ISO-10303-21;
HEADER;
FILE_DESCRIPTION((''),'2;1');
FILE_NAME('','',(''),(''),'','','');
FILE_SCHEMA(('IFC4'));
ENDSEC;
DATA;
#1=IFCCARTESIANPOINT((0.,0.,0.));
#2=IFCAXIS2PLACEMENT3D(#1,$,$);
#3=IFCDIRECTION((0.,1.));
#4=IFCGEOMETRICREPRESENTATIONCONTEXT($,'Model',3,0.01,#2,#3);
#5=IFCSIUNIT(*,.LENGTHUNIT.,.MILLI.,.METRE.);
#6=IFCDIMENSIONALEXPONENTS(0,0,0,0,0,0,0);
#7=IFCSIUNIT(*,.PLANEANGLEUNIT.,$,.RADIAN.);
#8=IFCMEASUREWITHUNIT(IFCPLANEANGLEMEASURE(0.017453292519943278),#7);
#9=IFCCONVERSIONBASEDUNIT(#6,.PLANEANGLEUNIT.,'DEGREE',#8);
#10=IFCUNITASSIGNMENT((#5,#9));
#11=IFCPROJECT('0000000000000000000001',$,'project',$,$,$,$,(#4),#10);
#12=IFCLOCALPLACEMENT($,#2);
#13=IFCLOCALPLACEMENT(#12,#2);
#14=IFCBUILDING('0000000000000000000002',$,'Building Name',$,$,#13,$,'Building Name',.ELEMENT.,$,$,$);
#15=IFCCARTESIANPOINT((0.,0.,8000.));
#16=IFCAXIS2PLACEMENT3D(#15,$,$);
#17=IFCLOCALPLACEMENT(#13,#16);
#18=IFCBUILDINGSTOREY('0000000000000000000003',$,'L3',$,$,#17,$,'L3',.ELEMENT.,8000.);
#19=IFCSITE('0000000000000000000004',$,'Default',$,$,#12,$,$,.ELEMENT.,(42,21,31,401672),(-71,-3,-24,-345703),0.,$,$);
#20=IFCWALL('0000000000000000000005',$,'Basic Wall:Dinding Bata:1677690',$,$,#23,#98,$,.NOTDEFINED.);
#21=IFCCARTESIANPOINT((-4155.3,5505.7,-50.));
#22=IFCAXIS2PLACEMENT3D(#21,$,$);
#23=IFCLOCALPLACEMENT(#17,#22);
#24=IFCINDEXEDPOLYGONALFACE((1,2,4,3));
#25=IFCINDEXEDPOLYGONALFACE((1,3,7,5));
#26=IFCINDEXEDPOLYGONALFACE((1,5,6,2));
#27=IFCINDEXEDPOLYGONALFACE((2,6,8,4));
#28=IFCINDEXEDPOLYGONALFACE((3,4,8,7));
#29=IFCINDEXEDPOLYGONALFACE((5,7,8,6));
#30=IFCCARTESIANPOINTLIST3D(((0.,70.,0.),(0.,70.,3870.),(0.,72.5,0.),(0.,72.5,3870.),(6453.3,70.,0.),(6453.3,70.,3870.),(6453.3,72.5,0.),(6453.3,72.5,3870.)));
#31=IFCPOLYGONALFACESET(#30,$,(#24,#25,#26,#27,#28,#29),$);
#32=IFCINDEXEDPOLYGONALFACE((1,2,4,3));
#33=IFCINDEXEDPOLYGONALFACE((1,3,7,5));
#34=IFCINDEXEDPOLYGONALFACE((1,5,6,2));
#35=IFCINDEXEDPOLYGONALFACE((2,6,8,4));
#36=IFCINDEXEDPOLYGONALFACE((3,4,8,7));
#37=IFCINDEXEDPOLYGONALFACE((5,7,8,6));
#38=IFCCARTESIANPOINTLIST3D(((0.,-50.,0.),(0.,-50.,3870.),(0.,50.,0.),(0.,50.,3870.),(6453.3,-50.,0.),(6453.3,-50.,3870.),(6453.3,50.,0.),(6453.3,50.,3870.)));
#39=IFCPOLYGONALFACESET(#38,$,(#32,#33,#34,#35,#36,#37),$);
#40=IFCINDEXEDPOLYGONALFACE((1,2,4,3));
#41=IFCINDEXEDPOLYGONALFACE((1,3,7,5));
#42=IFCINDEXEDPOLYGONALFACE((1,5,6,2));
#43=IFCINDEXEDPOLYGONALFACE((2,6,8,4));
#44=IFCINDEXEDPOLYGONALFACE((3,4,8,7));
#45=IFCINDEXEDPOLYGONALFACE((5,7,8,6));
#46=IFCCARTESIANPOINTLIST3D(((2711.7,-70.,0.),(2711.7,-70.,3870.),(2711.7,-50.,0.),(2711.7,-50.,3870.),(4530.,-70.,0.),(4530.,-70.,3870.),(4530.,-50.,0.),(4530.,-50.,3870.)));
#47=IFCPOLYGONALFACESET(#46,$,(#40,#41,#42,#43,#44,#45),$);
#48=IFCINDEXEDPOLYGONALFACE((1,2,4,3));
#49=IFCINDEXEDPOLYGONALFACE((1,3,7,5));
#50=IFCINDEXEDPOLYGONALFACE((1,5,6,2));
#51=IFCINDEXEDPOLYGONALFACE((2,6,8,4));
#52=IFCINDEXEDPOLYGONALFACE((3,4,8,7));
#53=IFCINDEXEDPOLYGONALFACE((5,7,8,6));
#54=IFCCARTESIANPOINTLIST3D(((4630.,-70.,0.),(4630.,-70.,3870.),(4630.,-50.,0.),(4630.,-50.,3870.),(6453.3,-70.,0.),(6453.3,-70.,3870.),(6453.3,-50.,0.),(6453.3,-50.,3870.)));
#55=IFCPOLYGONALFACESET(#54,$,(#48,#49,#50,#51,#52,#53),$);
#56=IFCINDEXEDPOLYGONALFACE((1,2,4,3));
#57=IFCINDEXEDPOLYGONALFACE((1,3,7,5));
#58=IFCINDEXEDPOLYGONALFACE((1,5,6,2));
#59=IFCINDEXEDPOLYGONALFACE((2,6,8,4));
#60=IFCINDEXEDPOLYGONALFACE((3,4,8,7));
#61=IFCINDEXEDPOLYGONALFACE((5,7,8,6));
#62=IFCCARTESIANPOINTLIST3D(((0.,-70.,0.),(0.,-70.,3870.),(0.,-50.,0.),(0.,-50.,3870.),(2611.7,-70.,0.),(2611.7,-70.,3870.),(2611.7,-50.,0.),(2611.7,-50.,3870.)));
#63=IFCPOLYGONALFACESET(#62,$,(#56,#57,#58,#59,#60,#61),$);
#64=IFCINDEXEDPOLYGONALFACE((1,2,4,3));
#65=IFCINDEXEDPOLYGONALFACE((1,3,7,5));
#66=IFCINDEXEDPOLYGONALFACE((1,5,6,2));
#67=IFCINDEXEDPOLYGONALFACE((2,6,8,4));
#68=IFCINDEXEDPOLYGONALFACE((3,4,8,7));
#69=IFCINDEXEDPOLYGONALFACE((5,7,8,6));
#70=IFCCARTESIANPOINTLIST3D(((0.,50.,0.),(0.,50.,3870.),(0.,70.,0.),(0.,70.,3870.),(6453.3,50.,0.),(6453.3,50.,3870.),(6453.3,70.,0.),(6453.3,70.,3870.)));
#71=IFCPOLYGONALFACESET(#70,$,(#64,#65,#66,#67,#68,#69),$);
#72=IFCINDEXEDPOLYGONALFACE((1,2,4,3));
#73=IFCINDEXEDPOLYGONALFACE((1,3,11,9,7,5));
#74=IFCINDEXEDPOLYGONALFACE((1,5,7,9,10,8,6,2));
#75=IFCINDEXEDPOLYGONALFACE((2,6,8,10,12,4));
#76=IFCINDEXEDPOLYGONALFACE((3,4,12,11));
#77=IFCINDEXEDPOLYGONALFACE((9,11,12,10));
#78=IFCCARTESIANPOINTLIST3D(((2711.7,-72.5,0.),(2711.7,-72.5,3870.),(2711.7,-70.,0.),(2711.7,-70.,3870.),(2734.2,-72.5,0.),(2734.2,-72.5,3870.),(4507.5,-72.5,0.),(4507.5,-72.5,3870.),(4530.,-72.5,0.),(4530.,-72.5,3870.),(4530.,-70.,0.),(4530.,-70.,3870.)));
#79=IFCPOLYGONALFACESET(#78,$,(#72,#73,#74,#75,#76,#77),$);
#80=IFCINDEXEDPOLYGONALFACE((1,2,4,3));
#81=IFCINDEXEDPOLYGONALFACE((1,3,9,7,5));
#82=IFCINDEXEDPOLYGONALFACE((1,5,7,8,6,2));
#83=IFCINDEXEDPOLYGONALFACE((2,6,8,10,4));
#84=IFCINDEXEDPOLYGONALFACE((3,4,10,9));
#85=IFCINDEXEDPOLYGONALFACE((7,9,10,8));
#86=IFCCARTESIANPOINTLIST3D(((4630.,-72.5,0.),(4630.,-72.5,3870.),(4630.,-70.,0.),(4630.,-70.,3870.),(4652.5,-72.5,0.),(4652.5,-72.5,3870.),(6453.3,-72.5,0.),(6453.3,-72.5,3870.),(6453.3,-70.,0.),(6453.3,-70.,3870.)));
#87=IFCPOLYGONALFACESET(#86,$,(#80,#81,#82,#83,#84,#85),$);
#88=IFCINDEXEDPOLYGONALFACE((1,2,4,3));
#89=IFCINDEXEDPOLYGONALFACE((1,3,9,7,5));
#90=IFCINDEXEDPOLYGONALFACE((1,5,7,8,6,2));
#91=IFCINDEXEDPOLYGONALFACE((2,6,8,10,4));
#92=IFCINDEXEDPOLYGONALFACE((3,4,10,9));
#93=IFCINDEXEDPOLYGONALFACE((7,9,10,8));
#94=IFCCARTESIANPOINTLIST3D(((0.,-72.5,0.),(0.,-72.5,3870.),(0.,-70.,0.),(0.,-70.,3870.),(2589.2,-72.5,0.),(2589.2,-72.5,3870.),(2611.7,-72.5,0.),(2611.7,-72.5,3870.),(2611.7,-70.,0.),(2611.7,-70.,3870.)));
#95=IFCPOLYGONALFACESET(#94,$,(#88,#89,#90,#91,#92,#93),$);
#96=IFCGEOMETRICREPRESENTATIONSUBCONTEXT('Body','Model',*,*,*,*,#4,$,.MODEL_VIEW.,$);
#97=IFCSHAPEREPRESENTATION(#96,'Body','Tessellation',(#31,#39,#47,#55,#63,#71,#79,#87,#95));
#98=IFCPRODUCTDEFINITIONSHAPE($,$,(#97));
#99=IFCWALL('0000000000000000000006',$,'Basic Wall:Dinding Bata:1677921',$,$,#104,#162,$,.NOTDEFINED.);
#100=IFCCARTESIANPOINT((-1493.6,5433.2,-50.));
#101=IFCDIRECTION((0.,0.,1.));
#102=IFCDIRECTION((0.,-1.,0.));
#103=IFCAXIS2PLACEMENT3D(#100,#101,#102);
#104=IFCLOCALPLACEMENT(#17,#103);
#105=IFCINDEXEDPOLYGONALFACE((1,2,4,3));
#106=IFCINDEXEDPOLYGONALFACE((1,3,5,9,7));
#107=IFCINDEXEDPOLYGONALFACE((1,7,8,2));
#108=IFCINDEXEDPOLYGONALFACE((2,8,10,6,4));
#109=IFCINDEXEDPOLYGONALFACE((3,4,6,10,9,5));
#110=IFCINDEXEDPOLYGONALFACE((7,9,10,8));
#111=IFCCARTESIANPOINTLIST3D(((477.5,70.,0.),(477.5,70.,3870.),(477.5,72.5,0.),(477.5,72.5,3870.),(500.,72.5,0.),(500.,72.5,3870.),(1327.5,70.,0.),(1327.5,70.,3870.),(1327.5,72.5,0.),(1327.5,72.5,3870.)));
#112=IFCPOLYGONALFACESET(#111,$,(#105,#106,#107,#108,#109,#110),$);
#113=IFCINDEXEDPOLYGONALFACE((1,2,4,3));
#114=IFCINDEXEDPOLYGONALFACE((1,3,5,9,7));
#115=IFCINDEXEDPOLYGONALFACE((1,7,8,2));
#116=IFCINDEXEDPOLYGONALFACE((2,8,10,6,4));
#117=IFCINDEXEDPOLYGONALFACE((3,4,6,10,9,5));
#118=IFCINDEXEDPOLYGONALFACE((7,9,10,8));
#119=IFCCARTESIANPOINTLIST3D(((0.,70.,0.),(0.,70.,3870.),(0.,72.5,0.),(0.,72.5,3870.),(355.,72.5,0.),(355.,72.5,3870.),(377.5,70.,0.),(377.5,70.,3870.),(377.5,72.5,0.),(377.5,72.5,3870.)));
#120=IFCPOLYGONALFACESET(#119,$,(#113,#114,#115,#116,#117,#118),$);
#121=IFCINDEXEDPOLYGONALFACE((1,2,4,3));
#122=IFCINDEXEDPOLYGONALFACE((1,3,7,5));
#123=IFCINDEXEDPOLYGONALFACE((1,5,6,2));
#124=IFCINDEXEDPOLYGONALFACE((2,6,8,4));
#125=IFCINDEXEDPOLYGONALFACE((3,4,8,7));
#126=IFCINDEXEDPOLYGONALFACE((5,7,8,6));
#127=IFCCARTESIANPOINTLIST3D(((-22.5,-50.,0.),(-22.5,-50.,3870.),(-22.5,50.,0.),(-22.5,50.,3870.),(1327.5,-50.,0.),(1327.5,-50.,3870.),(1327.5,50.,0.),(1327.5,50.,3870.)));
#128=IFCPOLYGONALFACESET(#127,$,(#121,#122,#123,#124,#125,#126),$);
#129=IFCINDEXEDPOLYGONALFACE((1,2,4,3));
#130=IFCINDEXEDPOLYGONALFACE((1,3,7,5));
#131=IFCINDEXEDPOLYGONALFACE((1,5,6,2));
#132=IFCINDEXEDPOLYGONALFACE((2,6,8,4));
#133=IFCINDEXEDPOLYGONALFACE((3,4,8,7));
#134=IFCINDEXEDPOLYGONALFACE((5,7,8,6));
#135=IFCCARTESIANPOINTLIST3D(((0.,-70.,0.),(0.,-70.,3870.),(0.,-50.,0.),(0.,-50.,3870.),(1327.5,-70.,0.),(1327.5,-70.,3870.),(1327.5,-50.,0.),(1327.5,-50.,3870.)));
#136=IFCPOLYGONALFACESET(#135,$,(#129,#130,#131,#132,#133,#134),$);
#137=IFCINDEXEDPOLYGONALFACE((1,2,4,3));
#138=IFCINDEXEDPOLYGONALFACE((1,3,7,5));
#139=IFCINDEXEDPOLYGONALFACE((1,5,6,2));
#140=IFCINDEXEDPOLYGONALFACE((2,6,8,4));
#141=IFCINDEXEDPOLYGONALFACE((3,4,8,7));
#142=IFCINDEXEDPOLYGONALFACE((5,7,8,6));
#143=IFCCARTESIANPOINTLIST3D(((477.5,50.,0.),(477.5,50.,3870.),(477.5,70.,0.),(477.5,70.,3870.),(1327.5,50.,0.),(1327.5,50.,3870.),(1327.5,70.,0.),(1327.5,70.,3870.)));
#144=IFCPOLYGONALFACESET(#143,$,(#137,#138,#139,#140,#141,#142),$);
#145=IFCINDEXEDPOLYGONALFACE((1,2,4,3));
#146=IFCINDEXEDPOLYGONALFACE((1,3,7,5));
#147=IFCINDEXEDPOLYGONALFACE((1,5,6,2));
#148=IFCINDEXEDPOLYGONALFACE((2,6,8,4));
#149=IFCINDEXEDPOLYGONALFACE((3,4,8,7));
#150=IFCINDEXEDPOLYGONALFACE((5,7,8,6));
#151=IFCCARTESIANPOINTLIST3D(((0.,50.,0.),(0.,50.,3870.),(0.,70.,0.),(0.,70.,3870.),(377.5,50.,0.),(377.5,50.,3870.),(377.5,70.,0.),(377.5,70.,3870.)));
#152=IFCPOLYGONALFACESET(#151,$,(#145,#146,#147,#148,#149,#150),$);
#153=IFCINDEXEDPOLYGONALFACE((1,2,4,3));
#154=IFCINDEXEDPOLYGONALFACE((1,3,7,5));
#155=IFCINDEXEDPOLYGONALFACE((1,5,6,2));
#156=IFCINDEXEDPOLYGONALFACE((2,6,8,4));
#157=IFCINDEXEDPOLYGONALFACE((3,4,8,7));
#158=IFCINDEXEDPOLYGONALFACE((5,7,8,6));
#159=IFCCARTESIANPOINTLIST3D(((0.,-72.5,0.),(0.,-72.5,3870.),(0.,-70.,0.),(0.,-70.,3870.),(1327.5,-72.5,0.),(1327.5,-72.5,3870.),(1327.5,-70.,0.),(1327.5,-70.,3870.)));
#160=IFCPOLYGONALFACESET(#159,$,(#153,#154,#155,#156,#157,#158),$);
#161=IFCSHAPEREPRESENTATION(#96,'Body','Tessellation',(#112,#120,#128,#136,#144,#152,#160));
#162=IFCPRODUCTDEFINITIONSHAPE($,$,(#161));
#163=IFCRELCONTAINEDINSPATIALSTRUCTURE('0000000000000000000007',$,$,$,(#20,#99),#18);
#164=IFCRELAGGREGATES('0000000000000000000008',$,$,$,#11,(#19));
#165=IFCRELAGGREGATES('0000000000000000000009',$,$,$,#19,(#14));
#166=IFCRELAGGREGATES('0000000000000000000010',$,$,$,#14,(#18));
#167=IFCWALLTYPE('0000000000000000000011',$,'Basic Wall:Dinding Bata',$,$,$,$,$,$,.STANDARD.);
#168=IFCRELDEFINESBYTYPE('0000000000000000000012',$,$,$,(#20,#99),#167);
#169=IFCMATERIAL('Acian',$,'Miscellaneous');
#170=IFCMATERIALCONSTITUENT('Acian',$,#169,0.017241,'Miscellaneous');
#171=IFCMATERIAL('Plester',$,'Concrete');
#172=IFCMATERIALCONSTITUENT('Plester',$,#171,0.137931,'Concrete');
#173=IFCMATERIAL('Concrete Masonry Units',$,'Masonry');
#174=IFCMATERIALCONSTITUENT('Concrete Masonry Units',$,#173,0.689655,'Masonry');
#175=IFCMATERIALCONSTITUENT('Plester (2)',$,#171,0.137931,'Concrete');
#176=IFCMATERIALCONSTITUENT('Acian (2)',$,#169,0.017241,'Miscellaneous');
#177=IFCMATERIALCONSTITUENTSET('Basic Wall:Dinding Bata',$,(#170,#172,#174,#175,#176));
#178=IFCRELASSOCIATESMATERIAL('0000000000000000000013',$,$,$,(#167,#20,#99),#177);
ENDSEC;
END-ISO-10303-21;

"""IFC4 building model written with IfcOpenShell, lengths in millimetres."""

from ifc_helpers import new_model, entity, si_unit, converted_unit, direction, frame, origin, place, context, subcontext, project, spatial, indexed_curve, outline, extrude, material, constituent, constituent_set, type_object, element, save


model = new_model("IFC4")

# Units and contexts
model_context = context("Model", 3, precision=0.01, world=origin(), true_north=direction((0.0, 1.0)))
body_context = subcontext(model_context, "Body", "Model", "MODEL_VIEW")
ifc_project = project(units=[si_unit("LENGTHUNIT", "METRE", prefix="MILLI"), converted_unit("PLANEANGLEUNIT", "DEGREE", entity("IfcPlaneAngleMeasure", 0.017453292519943278), si_unit("PLANEANGLEUNIT", "RADIAN"), dimensions=[0, 0, 0, 0, 0, 0, 0])], contexts=[model_context])

# Site, building, storey
site_placement = place(None, origin())
site = spatial("IfcSite", under=ifc_project, at=site_placement, Name="Default", CompositionType="ELEMENT", RefLatitude=(42, 21, 31, 401672), RefLongitude=(-71, -3, -24, -345703), RefElevation=0.0)
building_placement = place(site_placement, origin())
building = spatial("IfcBuilding", under=site, at=building_placement, Name="Building Name", LongName="Building Name", CompositionType="ELEMENT")
storey_placement = place(building_placement, frame((0.0, 0.0, 8000.0)))
storey = spatial("IfcBuildingStorey", under=building, at=storey_placement, Name="L3", LongName="L3", CompositionType="ELEMENT", Elevation=8000.0)

# Walls
ifc_material_1 = material(Name="Acian", Category="Miscellaneous")
ifc_constituent_1 = constituent(ifc_material_1, Name="Acian", Category="Miscellaneous", fraction=0.017241)
ifc_material_2 = material(Name="Plester", Category="Concrete")
ifc_constituent_2 = constituent(ifc_material_2, Name="Plester", Category="Concrete", fraction=0.137931)
ifc_material_3 = material(Name="Concrete Masonry Units", Category="Masonry")
ifc_constituent_3 = constituent(ifc_material_3, Name="Concrete Masonry Units", Category="Masonry", fraction=0.689655)
ifc_constituent_4 = constituent(ifc_material_2, Name="Plester (2)", Category="Concrete", fraction=0.137931)
ifc_constituent_5 = constituent(ifc_material_1, Name="Acian (2)", Category="Miscellaneous", fraction=0.017241)
ifc_constituent_set = constituent_set(constituents=[ifc_constituent_1, ifc_constituent_2, ifc_constituent_3, ifc_constituent_4, ifc_constituent_5], Name="Basic Wall:Dinding Bata")
wall_type = type_object("IfcWallType", Name="Basic Wall:Dinding Bata", PredefinedType="STANDARD", material=ifc_constituent_set)
wall_1_placement = place(storey_placement, frame((-4155.3, 5505.7, -50.0)))
element("IfcWall", 1, at=wall_1_placement, inside=storey, type_object=wall_type, material=ifc_constituent_set, Name="Basic Wall:Dinding Bata:1677690", PredefinedType="NOTDEFINED", context=body_context, shape_type="SweptSolid", body=[
    extrude(outline(indexed_curve([(-1.3, -3226.7), (1.2, -3226.7), (1.3, 3226.7), (-1.2, 3226.7), (-1.3, -3226.7)], self_intersect=False)), frame((3226.7, 71.3, 0.0), z_axis=(0.0, 0.0, 1.0), x_axis=(0.0, -1.0, 0.0)), (0.0, 0.0, 1.0), 3870.0),
    extrude(outline(indexed_curve([(-3226.7, -50.0), (3226.7, -50.0), (3226.7, 50.0), (-3226.7, 50.0), (-3226.7, -50.0)], self_intersect=False)), frame((3226.7, 0.0, 0.0)), (0.0, 0.0, 1.0), 3870.0),
    extrude(outline(indexed_curve([(-909.1, -10.0), (909.1, -10.0), (909.1, 10.0), (-909.1, 10.0), (-909.1, -10.0)], self_intersect=False)), frame((3620.9, -60.0, 0.0), z_axis=(0.0, 0.0, 1.0), x_axis=(-1.0, 0.0, 0.0)), (0.0, 0.0, 1.0), 3870.0),
    extrude(outline(indexed_curve([(-911.7, -10.0), (911.7, -10.0), (911.7, 10.0), (-911.7, 10.0), (-911.7, -10.0)], self_intersect=False)), frame((5541.7, -60.0, 0.0), z_axis=(0.0, 0.0, 1.0), x_axis=(-1.0, 0.0, 0.0)), (0.0, 0.0, 1.0), 3870.0),
    extrude(outline(indexed_curve([(-1305.9, -10.0), (1305.9, -10.0), (1305.9, 10.0), (-1305.9, 10.0), (-1305.9, -10.0)], self_intersect=False)), frame((1305.9, -60.0, 0.0)), (0.0, 0.0, 1.0), 3870.0),
    extrude(outline(indexed_curve([(-3226.7, -10.0), (3226.7, -10.0), (3226.7, 10.0), (-3226.7, 10.0), (-3226.7, -10.0)], self_intersect=False)), frame((3226.7, 60.0, 0.0)), (0.0, 0.0, 1.0), 3870.0),
    extrude(outline(indexed_curve([(886.6, -0.8), (909.1, -0.8), (909.1, 1.7), (-909.1, 1.7), (-909.1, -0.8), (-886.6, -0.8), (886.6, -0.8)], self_intersect=False)), frame((3620.9, -71.7, 0.0)), (0.0, 0.0, 1.0), 3870.0),
    extrude(outline(indexed_curve([(-1.0, -1089.5), (1.5, -1089.5), (1.5, 733.8), (-1.0, 733.8), (-1.0, 711.3), (-1.0, -1089.5)], self_intersect=False)), frame((5363.8, -71.5, 0.0), z_axis=(0.0, 0.0, 1.0), x_axis=(0.0, 1.0, 0.0)), (0.0, 0.0, 1.0), 3870.0),
    extrude(outline(indexed_curve([(1026.7, -1.0), (1049.2, -1.0), (1049.2, 1.5), (-1562.5, 1.5), (-1562.5, -1.0), (1026.7, -1.0)], self_intersect=False)), frame((1562.5, -71.5, 0.0)), (0.0, 0.0, 1.0), 3870.0),
])
wall_2_placement = place(storey_placement, frame((-1493.6, 5433.2, -50.0), z_axis=(0.0, 0.0, 1.0), x_axis=(0.0, -1.0, 0.0)))
element("IfcWall", 2, at=wall_2_placement, inside=storey, type_object=wall_type, material=ifc_constituent_set, Name="Basic Wall:Dinding Bata:1677921", PredefinedType="NOTDEFINED", context=body_context, shape_type="SweptSolid", body=[
    extrude(outline(indexed_curve([(322.0, -1.0), (344.5, -1.0), (344.5, 1.5), (-505.5, 1.5), (-505.5, -1.0), (322.0, -1.0)], self_intersect=False)), frame((822.0, 71.5, 0.0), z_axis=(0.0, 0.0, 1.0), x_axis=(-1.0, 0.0, 0.0)), (0.0, 0.0, 1.0), 3870.0),
    extrude(outline(indexed_curve([(-222.0, -1.5), (155.5, -1.5), (155.5, 1.0), (133.0, 1.0), (-222.0, 1.0), (-222.0, -1.5)], self_intersect=False)), frame((222.0, 71.5, 0.0)), (0.0, 0.0, 1.0), 3870.0),
    extrude(outline(indexed_curve([(-675.0, -50.0), (675.0, -50.0), (675.0, 50.0), (-675.0, 50.0), (-675.0, -50.0)], self_intersect=False)), frame((652.5, 0.0, 0.0)), (0.0, 0.0, 1.0), 3870.0),
    extrude(outline(indexed_curve([(-663.8, -10.0), (663.7, -10.0), (663.7, 10.0), (-663.8, 10.0), (-663.8, -10.0)], self_intersect=False)), frame((663.8, -60.0, 0.0)), (0.0, 0.0, 1.0), 3870.0),
    extrude(outline(indexed_curve([(-425.0, -10.0), (425.0, -10.0), (425.0, 10.0), (-425.0, 10.0), (-425.0, -10.0)], self_intersect=False)), frame((902.5, 60.0, 0.0), z_axis=(0.0, 0.0, 1.0), x_axis=(-1.0, 0.0, 0.0)), (0.0, 0.0, 1.0), 3870.0),
    extrude(outline(indexed_curve([(-188.8, -10.0), (188.8, -10.0), (188.8, 10.0), (-188.8, 10.0), (-188.8, -10.0)], self_intersect=False)), frame((188.8, 60.0, 0.0)), (0.0, 0.0, 1.0), 3870.0),
    extrude(outline(indexed_curve([(-1.3, -663.7), (1.2, -663.7), (1.3, 663.8), (-1.2, 663.8), (-1.3, -663.7)], self_intersect=False)), frame((663.8, -71.3, 0.0), z_axis=(0.0, 0.0, 1.0), x_axis=(0.0, 1.0, 0.0)), (0.0, 0.0, 1.0), 3870.0),
])

save(model, "model.ifc")
